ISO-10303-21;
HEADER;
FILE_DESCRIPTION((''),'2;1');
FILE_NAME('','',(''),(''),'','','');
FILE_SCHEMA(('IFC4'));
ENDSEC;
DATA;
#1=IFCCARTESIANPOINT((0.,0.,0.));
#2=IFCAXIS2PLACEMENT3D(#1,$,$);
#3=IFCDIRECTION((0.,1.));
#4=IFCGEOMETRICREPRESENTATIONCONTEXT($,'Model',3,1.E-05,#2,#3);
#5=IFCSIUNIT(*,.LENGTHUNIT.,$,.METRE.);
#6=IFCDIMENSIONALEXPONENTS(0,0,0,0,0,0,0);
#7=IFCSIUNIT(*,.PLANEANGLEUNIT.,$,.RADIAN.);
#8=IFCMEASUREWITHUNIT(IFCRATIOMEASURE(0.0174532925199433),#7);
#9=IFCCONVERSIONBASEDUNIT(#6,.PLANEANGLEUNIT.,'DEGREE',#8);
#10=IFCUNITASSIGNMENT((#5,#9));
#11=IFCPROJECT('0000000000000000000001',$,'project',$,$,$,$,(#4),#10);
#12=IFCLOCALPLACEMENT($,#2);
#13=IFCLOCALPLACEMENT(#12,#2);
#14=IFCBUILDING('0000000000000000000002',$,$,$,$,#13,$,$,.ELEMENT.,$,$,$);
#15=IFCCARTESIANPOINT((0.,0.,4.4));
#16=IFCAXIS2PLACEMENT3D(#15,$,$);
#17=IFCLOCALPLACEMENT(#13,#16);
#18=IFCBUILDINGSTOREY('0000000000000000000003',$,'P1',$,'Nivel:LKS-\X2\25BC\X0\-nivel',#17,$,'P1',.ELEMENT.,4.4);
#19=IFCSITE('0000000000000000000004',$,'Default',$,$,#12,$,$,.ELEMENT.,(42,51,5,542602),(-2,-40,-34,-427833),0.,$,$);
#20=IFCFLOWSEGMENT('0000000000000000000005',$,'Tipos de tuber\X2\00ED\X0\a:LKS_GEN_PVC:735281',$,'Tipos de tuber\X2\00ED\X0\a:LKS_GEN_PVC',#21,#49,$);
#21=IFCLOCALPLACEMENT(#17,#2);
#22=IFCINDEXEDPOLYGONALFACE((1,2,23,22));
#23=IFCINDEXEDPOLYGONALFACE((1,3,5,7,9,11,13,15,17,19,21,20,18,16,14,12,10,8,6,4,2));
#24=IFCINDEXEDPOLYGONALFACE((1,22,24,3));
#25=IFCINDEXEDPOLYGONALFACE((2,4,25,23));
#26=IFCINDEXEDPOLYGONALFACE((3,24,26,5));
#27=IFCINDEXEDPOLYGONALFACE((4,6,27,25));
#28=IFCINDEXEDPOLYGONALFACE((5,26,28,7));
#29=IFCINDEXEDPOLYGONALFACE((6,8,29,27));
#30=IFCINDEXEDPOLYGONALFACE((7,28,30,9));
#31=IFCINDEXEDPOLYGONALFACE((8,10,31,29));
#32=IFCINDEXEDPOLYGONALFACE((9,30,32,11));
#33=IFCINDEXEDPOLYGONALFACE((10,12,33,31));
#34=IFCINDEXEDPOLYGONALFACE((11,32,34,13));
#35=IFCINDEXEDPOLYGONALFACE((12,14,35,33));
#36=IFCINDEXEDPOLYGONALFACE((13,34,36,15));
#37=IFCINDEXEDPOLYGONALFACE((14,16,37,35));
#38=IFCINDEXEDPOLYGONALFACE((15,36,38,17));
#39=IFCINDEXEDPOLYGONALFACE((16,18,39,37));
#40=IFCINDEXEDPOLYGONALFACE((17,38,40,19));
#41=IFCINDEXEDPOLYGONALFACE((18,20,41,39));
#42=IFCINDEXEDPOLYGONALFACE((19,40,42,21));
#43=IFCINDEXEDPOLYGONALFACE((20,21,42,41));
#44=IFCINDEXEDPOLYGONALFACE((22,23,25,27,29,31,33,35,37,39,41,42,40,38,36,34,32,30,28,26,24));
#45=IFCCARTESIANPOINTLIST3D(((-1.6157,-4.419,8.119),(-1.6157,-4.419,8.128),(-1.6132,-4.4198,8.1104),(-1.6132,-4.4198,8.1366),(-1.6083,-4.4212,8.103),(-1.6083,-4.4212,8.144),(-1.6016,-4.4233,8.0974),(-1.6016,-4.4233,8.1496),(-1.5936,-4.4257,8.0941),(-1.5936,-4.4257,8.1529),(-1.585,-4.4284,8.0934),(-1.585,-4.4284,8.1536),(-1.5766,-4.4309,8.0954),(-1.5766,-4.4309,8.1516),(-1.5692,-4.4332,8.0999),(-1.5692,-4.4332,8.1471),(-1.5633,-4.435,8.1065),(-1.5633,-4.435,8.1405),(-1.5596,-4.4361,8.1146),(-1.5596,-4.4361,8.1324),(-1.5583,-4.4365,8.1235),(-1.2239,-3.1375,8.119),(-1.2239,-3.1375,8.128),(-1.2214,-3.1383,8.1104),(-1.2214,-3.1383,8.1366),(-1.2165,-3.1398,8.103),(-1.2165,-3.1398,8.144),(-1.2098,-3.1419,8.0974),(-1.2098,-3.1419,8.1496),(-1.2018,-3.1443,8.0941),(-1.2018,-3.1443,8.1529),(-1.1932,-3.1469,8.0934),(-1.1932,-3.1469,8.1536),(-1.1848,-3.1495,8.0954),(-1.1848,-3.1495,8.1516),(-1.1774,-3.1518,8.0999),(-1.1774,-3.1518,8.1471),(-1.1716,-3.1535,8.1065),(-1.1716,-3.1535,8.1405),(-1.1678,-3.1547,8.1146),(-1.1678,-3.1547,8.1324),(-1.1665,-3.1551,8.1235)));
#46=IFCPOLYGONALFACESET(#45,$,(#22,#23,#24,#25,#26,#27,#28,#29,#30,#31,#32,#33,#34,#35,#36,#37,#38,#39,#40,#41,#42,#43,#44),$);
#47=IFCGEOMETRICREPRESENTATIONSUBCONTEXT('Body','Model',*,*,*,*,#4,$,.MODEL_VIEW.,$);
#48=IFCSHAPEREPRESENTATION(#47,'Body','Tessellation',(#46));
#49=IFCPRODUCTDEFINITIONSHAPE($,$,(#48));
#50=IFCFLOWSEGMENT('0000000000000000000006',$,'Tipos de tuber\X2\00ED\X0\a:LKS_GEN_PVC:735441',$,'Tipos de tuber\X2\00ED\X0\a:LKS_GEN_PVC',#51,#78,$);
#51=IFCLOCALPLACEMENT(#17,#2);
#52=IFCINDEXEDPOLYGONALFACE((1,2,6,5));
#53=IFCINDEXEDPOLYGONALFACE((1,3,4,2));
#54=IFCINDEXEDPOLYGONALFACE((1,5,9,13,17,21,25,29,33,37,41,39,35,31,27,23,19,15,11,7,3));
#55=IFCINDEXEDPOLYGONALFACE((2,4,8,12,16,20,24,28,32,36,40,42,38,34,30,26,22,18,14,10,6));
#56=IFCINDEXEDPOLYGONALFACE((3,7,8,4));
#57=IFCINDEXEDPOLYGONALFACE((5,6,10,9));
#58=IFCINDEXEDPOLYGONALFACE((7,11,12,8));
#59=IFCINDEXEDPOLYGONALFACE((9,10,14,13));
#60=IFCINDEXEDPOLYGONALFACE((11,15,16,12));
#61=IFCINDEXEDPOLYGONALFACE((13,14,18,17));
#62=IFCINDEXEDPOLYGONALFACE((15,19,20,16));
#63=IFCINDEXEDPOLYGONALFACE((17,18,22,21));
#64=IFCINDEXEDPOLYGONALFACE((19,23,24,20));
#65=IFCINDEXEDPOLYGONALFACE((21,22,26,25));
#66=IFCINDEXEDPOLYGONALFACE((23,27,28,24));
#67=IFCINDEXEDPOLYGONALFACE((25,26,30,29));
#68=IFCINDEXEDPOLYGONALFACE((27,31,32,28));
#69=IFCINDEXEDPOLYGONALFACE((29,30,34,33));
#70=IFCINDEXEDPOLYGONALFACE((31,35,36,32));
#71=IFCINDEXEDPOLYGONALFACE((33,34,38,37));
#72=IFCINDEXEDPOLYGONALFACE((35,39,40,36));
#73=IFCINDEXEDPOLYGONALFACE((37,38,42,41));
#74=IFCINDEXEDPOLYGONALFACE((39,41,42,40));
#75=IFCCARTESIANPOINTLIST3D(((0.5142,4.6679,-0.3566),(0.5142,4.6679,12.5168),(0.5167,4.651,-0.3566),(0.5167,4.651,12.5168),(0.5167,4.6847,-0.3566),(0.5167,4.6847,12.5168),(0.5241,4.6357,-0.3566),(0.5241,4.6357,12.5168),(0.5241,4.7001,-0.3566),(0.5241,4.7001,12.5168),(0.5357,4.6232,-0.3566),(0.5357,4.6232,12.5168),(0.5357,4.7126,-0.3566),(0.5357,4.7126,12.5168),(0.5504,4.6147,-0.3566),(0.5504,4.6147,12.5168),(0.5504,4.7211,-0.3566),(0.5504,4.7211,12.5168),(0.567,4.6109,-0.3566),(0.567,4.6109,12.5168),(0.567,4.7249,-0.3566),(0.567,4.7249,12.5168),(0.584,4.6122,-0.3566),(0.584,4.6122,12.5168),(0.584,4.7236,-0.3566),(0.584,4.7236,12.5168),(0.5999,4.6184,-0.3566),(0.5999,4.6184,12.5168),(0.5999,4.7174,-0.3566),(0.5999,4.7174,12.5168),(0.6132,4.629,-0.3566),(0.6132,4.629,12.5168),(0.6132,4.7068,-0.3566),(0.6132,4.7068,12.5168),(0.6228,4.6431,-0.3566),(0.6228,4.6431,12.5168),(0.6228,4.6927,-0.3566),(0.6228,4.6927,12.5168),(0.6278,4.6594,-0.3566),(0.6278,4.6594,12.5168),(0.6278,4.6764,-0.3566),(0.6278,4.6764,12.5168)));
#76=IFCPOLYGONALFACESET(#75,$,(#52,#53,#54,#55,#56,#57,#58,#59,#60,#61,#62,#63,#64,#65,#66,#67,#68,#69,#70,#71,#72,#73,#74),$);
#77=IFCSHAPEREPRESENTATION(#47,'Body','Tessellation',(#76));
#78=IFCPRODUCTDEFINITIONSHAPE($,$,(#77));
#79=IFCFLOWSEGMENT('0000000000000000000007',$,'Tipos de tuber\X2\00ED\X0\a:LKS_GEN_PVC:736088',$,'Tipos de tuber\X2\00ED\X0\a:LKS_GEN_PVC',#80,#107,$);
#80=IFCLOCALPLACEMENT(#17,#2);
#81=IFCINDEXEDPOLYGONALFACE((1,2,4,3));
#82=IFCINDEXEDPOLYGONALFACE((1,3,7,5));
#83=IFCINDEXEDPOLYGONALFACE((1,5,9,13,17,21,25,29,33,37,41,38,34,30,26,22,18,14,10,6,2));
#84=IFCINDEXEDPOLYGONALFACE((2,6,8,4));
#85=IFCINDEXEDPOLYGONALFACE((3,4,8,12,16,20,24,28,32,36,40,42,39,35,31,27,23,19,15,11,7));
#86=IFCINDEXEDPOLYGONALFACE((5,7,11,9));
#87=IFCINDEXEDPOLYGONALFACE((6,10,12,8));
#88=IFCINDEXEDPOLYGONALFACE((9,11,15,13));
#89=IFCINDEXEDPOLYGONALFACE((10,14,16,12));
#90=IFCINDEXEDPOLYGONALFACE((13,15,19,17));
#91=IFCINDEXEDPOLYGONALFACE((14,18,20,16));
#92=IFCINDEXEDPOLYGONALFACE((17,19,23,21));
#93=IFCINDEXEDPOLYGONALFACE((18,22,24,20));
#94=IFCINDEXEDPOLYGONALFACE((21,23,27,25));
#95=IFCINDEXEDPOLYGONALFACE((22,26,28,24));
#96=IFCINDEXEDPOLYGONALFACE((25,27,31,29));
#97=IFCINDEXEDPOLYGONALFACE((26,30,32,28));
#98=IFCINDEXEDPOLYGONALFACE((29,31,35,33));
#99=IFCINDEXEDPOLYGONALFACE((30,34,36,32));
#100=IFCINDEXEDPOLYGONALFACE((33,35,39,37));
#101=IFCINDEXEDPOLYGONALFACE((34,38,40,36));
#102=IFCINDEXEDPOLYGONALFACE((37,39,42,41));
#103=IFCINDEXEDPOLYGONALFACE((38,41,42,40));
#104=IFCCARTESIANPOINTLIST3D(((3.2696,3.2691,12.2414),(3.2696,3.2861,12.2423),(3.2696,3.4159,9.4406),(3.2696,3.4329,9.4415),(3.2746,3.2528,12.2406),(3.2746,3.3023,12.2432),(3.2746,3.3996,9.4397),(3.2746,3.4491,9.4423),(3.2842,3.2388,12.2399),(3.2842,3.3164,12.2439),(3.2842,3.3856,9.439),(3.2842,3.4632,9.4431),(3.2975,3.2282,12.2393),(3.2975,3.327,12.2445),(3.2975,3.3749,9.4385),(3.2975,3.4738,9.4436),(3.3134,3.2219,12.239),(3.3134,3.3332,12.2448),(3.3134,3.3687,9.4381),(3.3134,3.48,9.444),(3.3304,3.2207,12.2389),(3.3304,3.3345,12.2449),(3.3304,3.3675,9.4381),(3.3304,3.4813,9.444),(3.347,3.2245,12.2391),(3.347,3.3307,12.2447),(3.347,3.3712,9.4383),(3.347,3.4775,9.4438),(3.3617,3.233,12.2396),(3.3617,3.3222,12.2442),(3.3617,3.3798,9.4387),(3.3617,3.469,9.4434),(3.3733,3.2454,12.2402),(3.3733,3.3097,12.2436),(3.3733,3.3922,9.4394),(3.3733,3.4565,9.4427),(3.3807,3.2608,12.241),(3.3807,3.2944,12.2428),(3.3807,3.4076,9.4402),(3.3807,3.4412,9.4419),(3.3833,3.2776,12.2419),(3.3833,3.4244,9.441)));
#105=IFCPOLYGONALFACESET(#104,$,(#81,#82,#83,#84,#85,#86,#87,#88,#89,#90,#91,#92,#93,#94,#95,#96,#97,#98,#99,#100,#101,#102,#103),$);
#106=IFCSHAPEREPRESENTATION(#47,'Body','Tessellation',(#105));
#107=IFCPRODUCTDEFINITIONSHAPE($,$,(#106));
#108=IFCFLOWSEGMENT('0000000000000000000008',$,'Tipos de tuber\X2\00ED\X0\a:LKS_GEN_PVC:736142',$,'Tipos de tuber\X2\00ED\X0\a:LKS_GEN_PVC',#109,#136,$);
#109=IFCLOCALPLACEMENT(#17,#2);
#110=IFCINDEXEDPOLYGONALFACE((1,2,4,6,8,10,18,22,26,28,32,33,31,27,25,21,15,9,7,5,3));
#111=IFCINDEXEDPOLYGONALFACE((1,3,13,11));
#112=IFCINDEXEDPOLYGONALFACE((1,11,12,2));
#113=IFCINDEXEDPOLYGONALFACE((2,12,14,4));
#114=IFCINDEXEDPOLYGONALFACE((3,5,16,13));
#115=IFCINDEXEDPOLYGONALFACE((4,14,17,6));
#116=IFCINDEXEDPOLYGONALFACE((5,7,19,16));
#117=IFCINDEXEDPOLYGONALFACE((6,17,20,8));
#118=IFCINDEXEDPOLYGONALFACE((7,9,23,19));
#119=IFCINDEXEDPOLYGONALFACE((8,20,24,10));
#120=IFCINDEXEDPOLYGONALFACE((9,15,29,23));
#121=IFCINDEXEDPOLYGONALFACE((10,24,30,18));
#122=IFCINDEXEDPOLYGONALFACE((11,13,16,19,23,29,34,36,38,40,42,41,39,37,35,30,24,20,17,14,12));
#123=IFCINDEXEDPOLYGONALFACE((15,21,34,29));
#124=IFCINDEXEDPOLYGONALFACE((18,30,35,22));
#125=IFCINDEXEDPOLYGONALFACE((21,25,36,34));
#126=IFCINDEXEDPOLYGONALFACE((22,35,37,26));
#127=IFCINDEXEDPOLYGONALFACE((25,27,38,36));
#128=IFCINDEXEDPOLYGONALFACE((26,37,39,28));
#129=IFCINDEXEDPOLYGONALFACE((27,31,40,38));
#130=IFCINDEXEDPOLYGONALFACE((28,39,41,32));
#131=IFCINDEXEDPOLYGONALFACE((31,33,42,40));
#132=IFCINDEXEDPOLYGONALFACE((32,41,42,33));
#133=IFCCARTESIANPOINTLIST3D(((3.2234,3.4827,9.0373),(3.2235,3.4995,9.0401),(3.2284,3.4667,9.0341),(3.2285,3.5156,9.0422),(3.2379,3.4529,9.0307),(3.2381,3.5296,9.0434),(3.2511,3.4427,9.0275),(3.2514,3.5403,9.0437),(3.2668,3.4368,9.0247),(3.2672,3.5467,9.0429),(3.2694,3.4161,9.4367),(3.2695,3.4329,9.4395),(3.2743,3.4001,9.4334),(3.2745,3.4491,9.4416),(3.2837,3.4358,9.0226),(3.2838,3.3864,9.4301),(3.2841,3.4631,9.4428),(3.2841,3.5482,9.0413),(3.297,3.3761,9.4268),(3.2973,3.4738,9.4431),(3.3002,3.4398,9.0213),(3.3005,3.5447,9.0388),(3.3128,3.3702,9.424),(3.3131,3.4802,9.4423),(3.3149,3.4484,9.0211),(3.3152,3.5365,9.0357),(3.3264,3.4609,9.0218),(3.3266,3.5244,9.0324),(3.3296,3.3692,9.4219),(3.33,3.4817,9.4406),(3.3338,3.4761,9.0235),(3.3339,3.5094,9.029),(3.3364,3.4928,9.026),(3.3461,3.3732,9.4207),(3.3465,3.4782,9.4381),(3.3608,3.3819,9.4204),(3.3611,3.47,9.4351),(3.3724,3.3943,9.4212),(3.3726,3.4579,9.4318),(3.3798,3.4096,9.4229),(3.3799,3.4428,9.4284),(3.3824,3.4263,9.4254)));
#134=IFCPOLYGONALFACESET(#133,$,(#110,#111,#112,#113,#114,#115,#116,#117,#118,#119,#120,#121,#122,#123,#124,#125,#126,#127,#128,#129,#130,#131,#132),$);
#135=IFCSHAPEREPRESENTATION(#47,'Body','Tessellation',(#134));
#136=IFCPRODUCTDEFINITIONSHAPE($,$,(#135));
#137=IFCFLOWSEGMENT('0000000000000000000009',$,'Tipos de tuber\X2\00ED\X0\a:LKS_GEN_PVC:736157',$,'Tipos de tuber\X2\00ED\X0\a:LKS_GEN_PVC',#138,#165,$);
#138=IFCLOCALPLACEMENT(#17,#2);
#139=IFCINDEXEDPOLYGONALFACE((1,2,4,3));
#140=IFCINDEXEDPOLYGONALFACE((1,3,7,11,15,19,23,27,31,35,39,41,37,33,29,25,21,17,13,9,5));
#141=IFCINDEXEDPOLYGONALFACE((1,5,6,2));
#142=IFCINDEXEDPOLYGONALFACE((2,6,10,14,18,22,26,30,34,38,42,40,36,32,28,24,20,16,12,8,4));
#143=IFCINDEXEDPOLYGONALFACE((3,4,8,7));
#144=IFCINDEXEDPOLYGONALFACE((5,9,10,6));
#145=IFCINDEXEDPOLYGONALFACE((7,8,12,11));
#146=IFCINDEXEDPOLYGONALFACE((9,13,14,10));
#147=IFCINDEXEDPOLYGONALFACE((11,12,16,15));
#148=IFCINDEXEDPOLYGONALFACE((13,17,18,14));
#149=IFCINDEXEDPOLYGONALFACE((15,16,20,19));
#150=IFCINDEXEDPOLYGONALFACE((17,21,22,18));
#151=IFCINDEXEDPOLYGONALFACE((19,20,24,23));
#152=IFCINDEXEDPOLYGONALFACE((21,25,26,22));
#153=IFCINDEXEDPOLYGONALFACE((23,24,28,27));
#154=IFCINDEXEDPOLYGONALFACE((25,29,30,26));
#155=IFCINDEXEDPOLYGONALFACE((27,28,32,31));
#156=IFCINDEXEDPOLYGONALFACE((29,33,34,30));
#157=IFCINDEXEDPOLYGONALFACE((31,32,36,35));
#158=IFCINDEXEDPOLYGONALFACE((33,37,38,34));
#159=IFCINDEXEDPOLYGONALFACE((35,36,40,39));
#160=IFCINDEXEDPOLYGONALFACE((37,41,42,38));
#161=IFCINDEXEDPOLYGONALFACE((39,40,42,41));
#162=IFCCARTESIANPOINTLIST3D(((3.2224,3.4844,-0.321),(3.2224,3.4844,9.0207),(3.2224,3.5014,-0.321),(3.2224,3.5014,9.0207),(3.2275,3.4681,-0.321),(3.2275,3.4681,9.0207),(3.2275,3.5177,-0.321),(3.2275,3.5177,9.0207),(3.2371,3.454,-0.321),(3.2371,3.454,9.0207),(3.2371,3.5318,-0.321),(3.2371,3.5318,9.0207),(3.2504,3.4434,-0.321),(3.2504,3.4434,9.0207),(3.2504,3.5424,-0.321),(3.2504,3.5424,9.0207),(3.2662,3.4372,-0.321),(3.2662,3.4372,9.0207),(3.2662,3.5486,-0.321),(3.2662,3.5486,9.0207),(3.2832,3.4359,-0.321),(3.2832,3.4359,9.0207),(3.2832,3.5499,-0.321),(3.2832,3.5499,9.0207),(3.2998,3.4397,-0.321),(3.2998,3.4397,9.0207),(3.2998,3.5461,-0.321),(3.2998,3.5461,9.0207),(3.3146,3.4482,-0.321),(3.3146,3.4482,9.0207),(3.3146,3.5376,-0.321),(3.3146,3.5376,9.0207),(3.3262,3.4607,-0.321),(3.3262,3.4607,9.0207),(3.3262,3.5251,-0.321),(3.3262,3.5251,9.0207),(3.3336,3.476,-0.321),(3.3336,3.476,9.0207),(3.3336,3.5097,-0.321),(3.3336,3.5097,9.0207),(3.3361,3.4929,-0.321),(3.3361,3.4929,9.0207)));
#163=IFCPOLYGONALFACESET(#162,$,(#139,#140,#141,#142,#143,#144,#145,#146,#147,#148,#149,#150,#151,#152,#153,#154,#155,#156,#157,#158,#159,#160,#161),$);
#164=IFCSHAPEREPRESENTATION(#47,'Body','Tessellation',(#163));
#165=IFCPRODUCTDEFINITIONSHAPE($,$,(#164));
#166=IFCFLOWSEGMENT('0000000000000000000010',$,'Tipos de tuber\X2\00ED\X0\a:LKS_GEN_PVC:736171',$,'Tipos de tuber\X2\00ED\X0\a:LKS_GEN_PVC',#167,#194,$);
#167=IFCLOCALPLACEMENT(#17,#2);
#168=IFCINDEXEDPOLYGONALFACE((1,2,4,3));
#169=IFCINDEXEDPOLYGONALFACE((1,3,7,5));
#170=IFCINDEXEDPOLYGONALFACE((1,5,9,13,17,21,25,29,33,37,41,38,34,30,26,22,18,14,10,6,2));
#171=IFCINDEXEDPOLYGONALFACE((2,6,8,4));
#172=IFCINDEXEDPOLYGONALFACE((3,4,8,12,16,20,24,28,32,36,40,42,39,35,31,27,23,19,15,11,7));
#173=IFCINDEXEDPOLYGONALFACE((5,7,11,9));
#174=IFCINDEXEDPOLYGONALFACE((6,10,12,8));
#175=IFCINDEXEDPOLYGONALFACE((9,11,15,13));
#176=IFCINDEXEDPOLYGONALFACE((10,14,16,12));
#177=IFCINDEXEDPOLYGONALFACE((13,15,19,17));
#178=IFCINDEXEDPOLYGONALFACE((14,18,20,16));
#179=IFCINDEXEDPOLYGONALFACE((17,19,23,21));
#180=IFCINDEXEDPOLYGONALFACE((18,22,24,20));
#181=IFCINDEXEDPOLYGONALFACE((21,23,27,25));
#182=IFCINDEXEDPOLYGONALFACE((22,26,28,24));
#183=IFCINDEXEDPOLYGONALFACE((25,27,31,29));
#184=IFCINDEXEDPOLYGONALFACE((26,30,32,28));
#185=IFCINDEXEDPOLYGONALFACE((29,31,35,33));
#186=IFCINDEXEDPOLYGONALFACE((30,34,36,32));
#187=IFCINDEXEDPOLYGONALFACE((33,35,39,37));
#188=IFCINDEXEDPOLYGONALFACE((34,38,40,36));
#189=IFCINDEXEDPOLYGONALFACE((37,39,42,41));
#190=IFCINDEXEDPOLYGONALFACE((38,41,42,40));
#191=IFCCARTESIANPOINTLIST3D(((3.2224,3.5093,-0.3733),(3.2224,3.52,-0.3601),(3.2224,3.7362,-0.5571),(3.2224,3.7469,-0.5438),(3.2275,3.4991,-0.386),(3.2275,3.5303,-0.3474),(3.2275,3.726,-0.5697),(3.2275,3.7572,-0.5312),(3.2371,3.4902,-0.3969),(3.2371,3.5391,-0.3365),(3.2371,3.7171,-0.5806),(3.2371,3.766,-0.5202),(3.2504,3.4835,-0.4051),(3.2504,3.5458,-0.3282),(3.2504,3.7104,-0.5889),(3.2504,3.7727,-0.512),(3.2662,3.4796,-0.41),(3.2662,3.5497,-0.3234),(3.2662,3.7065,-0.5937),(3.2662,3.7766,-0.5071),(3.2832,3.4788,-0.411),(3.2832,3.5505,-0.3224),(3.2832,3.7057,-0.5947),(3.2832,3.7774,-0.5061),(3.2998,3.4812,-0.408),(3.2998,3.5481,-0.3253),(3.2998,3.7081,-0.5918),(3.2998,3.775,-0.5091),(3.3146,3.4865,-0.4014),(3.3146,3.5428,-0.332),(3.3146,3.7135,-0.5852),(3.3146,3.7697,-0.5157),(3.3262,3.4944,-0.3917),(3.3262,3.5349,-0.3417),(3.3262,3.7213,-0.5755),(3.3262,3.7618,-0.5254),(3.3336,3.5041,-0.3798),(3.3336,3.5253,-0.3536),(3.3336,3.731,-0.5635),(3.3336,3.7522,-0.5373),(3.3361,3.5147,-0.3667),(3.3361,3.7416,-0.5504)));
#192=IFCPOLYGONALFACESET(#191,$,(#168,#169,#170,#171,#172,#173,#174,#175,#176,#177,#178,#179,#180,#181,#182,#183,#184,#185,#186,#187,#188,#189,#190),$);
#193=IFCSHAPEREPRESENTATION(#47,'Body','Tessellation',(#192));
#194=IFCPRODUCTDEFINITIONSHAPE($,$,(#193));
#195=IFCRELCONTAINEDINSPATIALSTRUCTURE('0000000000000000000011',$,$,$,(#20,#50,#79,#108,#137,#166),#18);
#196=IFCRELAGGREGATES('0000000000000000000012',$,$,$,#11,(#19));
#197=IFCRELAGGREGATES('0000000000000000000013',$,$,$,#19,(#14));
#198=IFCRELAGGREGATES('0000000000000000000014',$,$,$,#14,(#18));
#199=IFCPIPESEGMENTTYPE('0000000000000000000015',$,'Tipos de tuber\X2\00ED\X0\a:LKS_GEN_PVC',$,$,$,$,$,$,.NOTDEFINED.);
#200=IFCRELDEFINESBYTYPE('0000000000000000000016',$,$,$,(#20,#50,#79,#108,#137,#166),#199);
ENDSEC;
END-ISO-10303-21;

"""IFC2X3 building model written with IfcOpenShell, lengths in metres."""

from ifc_helpers import new_model, entity, si_unit, converted_unit, direction, frame, frame_2d, origin, origin_2d_with_axis, place, context, subcontext, project, spatial, circle, extrude, type_object, element, save


model = new_model("IFC2X3")

# Units and contexts
model_context = context("Model", 3, precision=1e-05, world=origin(), true_north=direction((0.0, 1.0)))
body_context = subcontext(model_context, "Body", "Model", "MODEL_VIEW")
ifc_project = project(units=[si_unit("LENGTHUNIT", "METRE"), converted_unit("PLANEANGLEUNIT", "DEGREE", entity("IfcRatioMeasure", 0.0174532925199433), si_unit("PLANEANGLEUNIT", "RADIAN"), dimensions=[0, 0, 0, 0, 0, 0, 0])], contexts=[model_context])

# Site, building, storey
site_placement = place(None, origin())
site = spatial("IfcSite", under=ifc_project, at=site_placement, Name="Default", CompositionType="ELEMENT", RefLatitude=(42, 51, 5, 542602), RefLongitude=(-2, -40, -34, -427833), RefElevation=0.0)
building_placement = place(site_placement, origin())
building = spatial("IfcBuilding", under=site, at=building_placement, CompositionType="ELEMENT")
storey_placement = place(building_placement, frame((0.0, 0.0, 4.4)))
storey = spatial("IfcBuildingStorey", under=building, at=storey_placement, Name="P1", ObjectType="Nivel:LKS-▼-nivel", LongName="P1", CompositionType="ELEMENT", Elevation=4.4)

# Flow segments
pipe_segment_type_1 = type_object("IfcPipeSegmentType", Name="Tipos de tubería:LKS_GEN_PVC", PredefinedType="NOTDEFINED")
flow_segment_1_placement = place(storey_placement, origin())
element("IfcFlowSegment", 1, at=flow_segment_1_placement, inside=storey, type_object=pipe_segment_type_1, Name="Tipos de tubería:LKS_GEN_PVC:735281", ObjectType="Tipos de tubería:LKS_GEN_PVC", context=body_context, shape_type="SweptSolid", body=[
    extrude(circle(Radius=0.0302, at=origin_2d_with_axis()), frame((-1.5872, -4.4277, 8.1235), z_axis=(0.292372, 0.956305, 0.0), x_axis=(0.956305, -0.292372, 0.0)), (0.0, 0.0, 1.0), 1.34),
])
flow_segment_2_placement = place(storey_placement, origin())
element("IfcFlowSegment", 2, at=flow_segment_2_placement, inside=storey, type_object=pipe_segment_type_1, Name="Tipos de tubería:LKS_GEN_PVC:735441", ObjectType="Tipos de tubería:LKS_GEN_PVC", context=body_context, shape_type="SweptSolid", body=[
    extrude(circle(Radius=0.0571, at=frame_2d((0.0, 0.0), x_axis=(1.0, 0.0))), frame((0.5713, 4.6679, -0.3566), z_axis=(0.0, 0.0, 1.0), x_axis=(-1.0, 0.0, 0.0)), (0.0, 0.0, 1.0), 12.8734),
])
flow_segment_3_placement = place(storey_placement, origin())
element("IfcFlowSegment", 3, at=flow_segment_3_placement, inside=storey, type_object=pipe_segment_type_1, Name="Tipos de tubería:LKS_GEN_PVC:736088", ObjectType="Tipos de tubería:LKS_GEN_PVC", context=body_context, shape_type="SweptSolid", body=[
    extrude(circle(Radius=0.0571, at=frame_2d((0.0, 0.0), x_axis=(1.0, 0.0))), frame((3.3261, 3.4244, 9.441), z_axis=(0.0, -0.052336, 0.99863), x_axis=(1.0, 0.0, 0.0)), (0.0, 0.0, 1.0), 2.8047),
])
flow_segment_4_placement = place(storey_placement, origin())
element("IfcFlowSegment", 4, at=flow_segment_4_placement, inside=storey, type_object=pipe_segment_type_1, Name="Tipos de tubería:LKS_GEN_PVC:736142", ObjectType="Tipos de tubería:LKS_GEN_PVC", context=body_context, shape_type="SweptSolid", body=[
    extrude(circle(Radius=0.0571, at=frame_2d((0.0, 0.0), x_axis=(1.0, 0.0))), frame((3.3256, 3.4254, 9.4318), z_axis=(-0.112776, 0.16329, -0.980111), x_axis=(0.822831, 0.568286, 0.0)), (0.0, 0.0, 1.0), 0.4075),
])
flow_segment_5_placement = place(storey_placement, origin())
element("IfcFlowSegment", 5, at=flow_segment_5_placement, inside=storey, type_object=pipe_segment_type_1, Name="Tipos de tubería:LKS_GEN_PVC:736157", ObjectType="Tipos de tubería:LKS_GEN_PVC", context=body_context, shape_type="SweptSolid", body=[
    extrude(circle(Radius=0.0571, at=origin_2d_with_axis()), frame((3.279, 3.4929, -0.321)), (0.0, 0.0, 1.0), 9.3418),
])
flow_segment_6_placement = place(storey_placement, origin())
element("IfcFlowSegment", 6, at=flow_segment_6_placement, inside=storey, type_object=pipe_segment_type_1, Name="Tipos de tubería:LKS_GEN_PVC:736171", ObjectType="Tipos de tubería:LKS_GEN_PVC", context=body_context, shape_type="SweptSolid", body=[
    extrude(circle(Radius=0.0571, at=frame_2d((0.0, 0.0), x_axis=(1.0, 0.0))), frame((3.279, 3.5147, -0.3667), z_axis=(0.0, 0.777146, -0.62932), x_axis=(1.0, 0.0, 0.0)), (0.0, 0.0, 1.0), 0.292),
])

save(model, "model.ifc")
